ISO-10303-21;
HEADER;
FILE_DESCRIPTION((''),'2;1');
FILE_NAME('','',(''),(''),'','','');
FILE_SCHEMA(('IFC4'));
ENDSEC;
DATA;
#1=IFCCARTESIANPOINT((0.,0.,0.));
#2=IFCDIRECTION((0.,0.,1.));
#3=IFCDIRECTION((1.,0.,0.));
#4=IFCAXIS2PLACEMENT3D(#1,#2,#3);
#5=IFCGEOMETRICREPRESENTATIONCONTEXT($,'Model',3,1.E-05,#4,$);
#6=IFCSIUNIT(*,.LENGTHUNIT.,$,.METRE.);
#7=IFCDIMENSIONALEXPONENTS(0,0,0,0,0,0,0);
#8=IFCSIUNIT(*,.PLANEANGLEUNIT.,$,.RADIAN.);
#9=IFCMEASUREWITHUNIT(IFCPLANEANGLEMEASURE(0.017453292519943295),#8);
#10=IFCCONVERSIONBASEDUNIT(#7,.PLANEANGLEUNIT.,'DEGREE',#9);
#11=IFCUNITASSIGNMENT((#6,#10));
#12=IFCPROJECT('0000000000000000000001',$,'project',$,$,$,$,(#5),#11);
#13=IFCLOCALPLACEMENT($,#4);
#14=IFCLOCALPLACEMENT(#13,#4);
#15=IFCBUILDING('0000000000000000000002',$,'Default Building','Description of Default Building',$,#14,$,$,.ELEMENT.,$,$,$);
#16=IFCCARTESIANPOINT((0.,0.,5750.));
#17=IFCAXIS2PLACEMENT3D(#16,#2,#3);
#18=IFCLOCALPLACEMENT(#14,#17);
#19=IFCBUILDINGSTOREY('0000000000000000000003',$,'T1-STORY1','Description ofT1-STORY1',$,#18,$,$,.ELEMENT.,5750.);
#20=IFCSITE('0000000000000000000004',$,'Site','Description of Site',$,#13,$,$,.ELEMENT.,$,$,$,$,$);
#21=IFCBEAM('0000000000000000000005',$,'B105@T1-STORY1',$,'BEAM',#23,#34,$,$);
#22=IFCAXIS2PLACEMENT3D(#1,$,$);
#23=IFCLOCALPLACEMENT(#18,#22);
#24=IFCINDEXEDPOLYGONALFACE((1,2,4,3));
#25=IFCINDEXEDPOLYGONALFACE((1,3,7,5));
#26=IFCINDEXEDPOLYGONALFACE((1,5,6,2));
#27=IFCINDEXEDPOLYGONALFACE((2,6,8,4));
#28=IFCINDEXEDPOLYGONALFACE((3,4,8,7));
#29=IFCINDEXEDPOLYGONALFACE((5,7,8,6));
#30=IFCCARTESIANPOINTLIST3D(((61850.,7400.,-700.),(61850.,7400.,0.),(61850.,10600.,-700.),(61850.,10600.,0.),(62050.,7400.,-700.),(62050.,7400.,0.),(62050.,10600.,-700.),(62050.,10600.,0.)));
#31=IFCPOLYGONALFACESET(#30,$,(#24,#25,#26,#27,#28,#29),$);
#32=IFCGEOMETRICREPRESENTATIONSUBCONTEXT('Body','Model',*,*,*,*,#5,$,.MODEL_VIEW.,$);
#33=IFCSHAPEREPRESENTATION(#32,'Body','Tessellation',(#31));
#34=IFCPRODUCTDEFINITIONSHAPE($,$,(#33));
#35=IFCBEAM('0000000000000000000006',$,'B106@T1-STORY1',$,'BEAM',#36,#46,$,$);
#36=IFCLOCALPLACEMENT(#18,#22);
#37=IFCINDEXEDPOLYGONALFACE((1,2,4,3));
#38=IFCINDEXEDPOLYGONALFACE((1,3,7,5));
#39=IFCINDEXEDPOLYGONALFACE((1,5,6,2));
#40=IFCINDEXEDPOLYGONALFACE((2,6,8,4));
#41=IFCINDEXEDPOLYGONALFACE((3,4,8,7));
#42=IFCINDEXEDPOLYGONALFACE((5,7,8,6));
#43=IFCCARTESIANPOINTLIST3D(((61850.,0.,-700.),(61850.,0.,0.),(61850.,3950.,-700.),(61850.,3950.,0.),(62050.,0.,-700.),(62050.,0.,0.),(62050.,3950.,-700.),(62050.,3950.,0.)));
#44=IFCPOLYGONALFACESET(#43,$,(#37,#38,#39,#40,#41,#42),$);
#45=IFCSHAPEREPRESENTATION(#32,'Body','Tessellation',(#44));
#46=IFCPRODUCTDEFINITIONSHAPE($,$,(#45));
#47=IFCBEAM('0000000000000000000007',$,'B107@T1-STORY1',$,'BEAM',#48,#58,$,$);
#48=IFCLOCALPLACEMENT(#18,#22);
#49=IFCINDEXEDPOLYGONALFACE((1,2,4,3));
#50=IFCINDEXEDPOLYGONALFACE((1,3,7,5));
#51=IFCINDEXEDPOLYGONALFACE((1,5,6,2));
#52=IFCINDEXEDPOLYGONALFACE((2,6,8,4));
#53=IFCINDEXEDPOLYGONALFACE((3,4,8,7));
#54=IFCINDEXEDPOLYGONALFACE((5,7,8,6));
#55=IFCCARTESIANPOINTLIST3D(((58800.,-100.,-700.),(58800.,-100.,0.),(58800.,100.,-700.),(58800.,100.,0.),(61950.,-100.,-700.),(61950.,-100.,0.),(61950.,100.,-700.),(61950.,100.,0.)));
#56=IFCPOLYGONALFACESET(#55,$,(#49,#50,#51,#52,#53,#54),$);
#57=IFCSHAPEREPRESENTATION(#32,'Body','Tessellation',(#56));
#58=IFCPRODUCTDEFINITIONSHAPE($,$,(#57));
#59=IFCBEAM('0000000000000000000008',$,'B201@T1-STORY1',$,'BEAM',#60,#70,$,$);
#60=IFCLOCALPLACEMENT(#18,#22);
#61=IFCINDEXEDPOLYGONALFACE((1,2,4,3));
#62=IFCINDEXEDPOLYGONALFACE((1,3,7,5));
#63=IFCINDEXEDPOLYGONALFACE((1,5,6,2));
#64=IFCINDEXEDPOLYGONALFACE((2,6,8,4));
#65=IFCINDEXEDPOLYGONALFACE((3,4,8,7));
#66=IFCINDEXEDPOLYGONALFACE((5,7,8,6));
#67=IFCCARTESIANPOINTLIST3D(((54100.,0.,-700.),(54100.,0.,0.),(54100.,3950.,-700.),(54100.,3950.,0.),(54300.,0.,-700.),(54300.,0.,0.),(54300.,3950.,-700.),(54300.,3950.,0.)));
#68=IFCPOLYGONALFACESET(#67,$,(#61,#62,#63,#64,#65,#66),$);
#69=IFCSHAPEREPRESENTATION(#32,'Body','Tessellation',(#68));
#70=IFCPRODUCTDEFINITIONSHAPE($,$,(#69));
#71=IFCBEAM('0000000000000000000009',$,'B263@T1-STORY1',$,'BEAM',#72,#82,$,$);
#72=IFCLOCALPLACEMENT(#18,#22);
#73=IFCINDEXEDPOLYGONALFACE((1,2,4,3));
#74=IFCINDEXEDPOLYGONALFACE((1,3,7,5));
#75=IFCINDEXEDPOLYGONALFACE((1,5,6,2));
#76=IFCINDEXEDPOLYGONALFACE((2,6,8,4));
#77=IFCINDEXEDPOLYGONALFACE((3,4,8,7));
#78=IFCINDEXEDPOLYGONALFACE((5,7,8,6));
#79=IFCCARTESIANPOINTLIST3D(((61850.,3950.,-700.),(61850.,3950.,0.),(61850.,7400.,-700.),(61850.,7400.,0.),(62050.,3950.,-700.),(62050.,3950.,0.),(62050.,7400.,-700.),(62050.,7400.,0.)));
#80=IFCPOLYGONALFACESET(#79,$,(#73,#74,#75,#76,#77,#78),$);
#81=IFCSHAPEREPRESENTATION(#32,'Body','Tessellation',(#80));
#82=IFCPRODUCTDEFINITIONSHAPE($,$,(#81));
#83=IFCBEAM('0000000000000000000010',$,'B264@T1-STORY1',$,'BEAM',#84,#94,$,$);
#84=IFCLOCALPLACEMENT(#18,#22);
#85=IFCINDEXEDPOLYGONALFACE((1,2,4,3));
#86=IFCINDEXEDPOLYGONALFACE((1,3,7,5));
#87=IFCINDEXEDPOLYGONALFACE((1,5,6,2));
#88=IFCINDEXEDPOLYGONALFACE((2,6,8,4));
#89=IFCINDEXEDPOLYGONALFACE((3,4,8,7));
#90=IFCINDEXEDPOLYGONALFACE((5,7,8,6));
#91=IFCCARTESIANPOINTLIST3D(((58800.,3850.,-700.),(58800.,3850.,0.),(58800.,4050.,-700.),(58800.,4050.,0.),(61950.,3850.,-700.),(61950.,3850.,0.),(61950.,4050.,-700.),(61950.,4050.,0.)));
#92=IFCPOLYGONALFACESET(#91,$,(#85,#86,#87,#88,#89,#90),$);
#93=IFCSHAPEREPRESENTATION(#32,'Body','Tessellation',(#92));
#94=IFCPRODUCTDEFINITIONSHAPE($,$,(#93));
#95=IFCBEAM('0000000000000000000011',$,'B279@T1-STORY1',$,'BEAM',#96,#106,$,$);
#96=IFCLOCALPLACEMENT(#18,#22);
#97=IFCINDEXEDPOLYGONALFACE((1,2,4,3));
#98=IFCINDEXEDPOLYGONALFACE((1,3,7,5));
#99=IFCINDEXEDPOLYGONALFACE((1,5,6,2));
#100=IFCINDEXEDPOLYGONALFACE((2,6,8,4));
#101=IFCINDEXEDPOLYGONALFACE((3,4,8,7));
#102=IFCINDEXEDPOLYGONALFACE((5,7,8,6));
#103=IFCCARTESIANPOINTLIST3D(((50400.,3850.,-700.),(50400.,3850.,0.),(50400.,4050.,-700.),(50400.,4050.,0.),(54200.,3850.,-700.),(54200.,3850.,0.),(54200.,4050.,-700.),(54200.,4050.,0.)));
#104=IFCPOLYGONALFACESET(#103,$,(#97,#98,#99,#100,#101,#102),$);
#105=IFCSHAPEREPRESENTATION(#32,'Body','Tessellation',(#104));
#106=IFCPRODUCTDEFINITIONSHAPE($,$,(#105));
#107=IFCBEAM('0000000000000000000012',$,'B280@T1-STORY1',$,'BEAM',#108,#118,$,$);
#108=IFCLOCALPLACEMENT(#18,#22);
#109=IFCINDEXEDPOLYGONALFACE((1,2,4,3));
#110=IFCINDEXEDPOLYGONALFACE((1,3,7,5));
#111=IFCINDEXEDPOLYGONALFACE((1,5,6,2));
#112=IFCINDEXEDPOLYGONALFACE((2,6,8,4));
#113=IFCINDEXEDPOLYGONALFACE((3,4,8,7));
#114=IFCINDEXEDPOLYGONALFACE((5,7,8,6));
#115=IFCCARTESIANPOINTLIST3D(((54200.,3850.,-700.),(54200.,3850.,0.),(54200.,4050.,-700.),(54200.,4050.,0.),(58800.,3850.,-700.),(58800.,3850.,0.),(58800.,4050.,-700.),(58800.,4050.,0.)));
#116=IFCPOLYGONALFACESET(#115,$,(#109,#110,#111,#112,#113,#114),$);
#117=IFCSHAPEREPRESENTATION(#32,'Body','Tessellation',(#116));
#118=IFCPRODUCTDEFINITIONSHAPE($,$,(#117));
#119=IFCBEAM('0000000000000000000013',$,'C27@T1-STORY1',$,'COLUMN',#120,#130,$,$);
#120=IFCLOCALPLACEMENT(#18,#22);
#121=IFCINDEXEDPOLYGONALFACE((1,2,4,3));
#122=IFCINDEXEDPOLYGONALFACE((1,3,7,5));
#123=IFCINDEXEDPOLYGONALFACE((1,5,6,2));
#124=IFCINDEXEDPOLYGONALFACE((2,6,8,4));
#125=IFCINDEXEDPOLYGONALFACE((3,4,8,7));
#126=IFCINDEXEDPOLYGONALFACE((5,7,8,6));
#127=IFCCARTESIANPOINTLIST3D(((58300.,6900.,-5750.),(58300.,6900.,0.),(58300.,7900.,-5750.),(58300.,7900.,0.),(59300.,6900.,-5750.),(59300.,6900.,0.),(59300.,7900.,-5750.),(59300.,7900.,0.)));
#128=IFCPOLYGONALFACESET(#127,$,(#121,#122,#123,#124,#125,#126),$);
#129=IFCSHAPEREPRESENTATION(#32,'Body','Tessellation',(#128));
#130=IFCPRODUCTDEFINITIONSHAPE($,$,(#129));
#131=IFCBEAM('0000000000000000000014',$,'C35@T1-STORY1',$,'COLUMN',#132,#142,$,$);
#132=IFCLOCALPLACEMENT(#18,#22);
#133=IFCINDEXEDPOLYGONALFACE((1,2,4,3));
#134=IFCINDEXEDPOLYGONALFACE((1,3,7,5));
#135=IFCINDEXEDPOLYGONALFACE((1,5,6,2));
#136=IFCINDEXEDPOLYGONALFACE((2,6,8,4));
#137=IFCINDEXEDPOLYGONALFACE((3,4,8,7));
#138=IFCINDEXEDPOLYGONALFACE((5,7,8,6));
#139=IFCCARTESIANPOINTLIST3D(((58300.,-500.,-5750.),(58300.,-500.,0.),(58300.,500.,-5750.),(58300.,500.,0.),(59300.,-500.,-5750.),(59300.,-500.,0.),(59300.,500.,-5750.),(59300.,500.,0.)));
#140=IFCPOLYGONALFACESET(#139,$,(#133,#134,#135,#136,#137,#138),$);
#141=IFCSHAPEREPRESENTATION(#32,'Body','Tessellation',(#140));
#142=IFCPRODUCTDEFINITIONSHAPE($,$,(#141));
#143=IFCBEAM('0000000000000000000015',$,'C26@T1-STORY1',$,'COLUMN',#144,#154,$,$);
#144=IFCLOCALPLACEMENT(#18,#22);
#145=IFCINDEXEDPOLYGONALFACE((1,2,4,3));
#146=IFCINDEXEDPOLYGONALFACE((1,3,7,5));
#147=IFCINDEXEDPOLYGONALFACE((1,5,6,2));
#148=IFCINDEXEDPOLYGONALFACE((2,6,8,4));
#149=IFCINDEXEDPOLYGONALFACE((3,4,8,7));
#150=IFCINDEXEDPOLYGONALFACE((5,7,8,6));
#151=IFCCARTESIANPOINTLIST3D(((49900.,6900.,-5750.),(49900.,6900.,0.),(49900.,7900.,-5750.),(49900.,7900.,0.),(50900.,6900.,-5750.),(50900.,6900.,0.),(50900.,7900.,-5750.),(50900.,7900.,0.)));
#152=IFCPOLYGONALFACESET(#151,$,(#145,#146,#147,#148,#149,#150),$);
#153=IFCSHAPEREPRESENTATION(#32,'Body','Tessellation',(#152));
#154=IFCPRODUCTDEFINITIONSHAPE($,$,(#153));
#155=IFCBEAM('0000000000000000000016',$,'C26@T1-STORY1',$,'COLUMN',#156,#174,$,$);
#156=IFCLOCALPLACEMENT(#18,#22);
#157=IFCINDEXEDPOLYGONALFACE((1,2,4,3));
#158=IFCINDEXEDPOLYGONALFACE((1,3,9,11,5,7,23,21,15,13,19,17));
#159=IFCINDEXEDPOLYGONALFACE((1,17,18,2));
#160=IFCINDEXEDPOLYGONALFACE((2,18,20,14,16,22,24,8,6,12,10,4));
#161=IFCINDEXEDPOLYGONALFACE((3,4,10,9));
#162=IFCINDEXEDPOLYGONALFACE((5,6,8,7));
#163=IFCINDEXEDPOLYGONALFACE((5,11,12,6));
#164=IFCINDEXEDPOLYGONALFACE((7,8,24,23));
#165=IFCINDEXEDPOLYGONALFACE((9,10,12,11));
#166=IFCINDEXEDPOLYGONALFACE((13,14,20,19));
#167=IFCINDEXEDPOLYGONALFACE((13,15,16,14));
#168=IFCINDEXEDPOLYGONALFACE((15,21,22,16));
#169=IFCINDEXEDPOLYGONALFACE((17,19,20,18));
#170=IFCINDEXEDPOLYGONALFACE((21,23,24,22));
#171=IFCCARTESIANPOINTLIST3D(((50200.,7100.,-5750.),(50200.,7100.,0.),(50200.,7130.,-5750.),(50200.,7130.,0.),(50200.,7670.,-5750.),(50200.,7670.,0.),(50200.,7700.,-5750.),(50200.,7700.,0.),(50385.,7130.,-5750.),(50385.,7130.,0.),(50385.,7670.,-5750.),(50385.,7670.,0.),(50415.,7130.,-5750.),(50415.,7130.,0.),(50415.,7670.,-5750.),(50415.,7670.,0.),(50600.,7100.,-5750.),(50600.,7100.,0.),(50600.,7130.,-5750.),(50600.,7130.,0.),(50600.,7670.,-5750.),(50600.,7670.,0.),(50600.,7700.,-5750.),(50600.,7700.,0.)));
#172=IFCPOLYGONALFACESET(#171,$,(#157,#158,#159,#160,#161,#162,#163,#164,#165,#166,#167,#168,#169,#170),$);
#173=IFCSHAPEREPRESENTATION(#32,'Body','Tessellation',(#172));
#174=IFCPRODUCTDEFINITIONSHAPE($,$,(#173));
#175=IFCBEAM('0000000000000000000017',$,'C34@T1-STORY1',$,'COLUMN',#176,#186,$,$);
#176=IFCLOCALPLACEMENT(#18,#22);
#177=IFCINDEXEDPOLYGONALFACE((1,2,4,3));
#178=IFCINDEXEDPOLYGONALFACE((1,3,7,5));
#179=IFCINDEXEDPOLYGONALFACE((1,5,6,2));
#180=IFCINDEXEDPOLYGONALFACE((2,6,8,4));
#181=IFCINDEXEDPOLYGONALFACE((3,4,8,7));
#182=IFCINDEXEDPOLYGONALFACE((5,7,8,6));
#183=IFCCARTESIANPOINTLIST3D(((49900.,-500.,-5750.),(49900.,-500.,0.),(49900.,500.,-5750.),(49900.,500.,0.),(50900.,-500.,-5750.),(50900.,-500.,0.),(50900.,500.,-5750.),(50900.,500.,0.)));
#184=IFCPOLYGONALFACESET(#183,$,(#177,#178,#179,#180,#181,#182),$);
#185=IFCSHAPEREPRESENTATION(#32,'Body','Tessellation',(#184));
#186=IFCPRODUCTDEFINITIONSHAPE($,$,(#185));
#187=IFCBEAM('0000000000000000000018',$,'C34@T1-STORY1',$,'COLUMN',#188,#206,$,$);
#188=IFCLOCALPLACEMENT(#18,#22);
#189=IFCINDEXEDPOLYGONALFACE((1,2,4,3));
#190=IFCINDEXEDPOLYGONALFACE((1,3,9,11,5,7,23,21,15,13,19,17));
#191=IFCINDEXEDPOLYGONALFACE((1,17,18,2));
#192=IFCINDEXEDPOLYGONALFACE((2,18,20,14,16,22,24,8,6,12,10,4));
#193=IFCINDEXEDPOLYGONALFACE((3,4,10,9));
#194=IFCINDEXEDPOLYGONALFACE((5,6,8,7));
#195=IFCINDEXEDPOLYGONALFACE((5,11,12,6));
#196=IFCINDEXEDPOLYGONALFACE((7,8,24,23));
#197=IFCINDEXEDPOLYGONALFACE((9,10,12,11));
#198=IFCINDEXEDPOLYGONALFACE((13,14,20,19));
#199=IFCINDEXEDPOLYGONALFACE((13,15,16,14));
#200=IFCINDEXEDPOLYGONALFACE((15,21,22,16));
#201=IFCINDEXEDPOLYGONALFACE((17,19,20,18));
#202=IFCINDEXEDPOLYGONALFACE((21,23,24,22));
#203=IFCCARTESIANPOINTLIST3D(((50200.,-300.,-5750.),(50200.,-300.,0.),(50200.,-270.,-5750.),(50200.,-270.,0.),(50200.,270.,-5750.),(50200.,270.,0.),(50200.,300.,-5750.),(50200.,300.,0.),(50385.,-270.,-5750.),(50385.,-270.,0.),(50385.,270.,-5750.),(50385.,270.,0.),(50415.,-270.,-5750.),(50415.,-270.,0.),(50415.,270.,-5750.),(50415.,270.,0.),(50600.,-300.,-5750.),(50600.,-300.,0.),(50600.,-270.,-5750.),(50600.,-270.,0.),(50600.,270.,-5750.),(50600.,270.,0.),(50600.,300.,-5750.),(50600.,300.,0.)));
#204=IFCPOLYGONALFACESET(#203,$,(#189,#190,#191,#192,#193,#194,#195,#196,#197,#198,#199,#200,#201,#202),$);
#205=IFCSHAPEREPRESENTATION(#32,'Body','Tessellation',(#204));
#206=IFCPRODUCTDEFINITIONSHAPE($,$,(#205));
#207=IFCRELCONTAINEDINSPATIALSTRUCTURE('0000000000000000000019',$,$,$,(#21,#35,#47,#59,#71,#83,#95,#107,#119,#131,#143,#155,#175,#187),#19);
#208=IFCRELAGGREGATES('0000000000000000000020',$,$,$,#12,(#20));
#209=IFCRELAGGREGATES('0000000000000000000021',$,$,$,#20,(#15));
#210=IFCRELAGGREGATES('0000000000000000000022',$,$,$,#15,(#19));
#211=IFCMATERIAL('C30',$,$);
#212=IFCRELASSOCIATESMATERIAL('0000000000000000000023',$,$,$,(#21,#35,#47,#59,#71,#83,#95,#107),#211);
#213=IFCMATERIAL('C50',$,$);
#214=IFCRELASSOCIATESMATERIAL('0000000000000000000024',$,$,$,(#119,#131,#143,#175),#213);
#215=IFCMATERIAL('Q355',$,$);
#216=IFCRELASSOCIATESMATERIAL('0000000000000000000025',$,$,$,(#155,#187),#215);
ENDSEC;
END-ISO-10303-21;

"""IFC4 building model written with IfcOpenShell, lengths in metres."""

from ifc_helpers import new_model, entity, si_unit, converted_unit, frame, origin_with_axes, place, context, subcontext, project, spatial, rectangle, i_section, extrude, material, element, save


model = new_model("IFC4")

# Units and contexts
model_context = context("Model", 3, precision=1e-05, world=origin_with_axes())
body_context = subcontext(model_context, "Body", "Model", "MODEL_VIEW")
ifc_project = project(units=[si_unit("LENGTHUNIT", "METRE"), converted_unit("PLANEANGLEUNIT", "DEGREE", entity("IfcPlaneAngleMeasure", 0.017453292519943295), si_unit("PLANEANGLEUNIT", "RADIAN"), dimensions=[0, 0, 0, 0, 0, 0, 0])], contexts=[model_context])

# Site, building, storey
site_placement = place(None, origin_with_axes())
site = spatial("IfcSite", under=ifc_project, at=site_placement, Name="Site", Description="Description of Site", CompositionType="ELEMENT")
building_placement = place(site_placement, origin_with_axes())
building = spatial("IfcBuilding", under=site, at=building_placement, Name="Default Building", Description="Description of Default Building", CompositionType="ELEMENT")
storey_placement = place(building_placement, frame((0.0, 0.0, 5750.0), z_axis=(0.0, 0.0, 1.0), x_axis=(1.0, 0.0, 0.0)))
storey = spatial("IfcBuildingStorey", under=building, at=storey_placement, Name="T1-STORY1", Description="Description ofT1-STORY1", CompositionType="ELEMENT", Elevation=5750.0)

# Beams
ifc_material_1 = material(Name="C30")
beam_1_placement = place(storey_placement, frame((61950.0, 7400.0, -350.0), z_axis=(0.0, 1.0, 0.0), x_axis=(-1.0, 0.0, 0.0)))
element("IfcBeam", 1, at=beam_1_placement, inside=storey, material=ifc_material_1, Name="B105@T1-STORY1", ObjectType="BEAM", context=body_context, shape_type="SweptSolid", body=[
    extrude(rectangle(XDim=200.0, YDim=700.0), origin_with_axes(), (0.0, 0.0, 1.0), 3200.0),
])
beam_2_placement = place(storey_placement, frame((61950.0, 0.0, -350.0), z_axis=(0.0, 1.0, 0.0), x_axis=(-1.0, 0.0, 0.0)))
element("IfcBeam", 2, at=beam_2_placement, inside=storey, material=ifc_material_1, Name="B106@T1-STORY1", ObjectType="BEAM", context=body_context, shape_type="SweptSolid", body=[
    extrude(rectangle(XDim=200.0, YDim=700.0), origin_with_axes(), (0.0, 0.0, 1.0), 3950.0),
])
beam_3_placement = place(storey_placement, frame((58800.0, 0.0, -350.0), z_axis=(1.0, 0.0, 0.0), x_axis=(0.0, 1.0, 0.0)))
element("IfcBeam", 3, at=beam_3_placement, inside=storey, material=ifc_material_1, Name="B107@T1-STORY1", ObjectType="BEAM", context=body_context, shape_type="SweptSolid", body=[
    extrude(rectangle(XDim=200.0, YDim=700.0), origin_with_axes(), (0.0, 0.0, 1.0), 3150.0),
])
beam_4_placement = place(storey_placement, frame((54200.0, 0.0, -350.0), z_axis=(0.0, 1.0, 0.0), x_axis=(-1.0, 0.0, 0.0)))
element("IfcBeam", 4, at=beam_4_placement, inside=storey, material=ifc_material_1, Name="B201@T1-STORY1", ObjectType="BEAM", context=body_context, shape_type="SweptSolid", body=[
    extrude(rectangle(XDim=200.0, YDim=700.0), origin_with_axes(), (0.0, 0.0, 1.0), 3950.0),
])
beam_5_placement = place(storey_placement, frame((61950.0, 3950.0, -350.0), z_axis=(0.0, 1.0, 0.0), x_axis=(-1.0, 0.0, 0.0)))
element("IfcBeam", 5, at=beam_5_placement, inside=storey, material=ifc_material_1, Name="B263@T1-STORY1", ObjectType="BEAM", context=body_context, shape_type="SweptSolid", body=[
    extrude(rectangle(XDim=200.0, YDim=700.0), origin_with_axes(), (0.0, 0.0, 1.0), 3450.0),
])
beam_6_placement = place(storey_placement, frame((58800.0, 3950.0, -350.0), z_axis=(1.0, 0.0, 0.0), x_axis=(0.0, 1.0, 0.0)))
element("IfcBeam", 6, at=beam_6_placement, inside=storey, material=ifc_material_1, Name="B264@T1-STORY1", ObjectType="BEAM", context=body_context, shape_type="SweptSolid", body=[
    extrude(rectangle(XDim=200.0, YDim=700.0), origin_with_axes(), (0.0, 0.0, 1.0), 3150.0),
])
beam_7_placement = place(storey_placement, frame((50400.0, 3950.0, -350.0), z_axis=(1.0, 0.0, 0.0), x_axis=(0.0, 1.0, 0.0)))
element("IfcBeam", 7, at=beam_7_placement, inside=storey, material=ifc_material_1, Name="B279@T1-STORY1", ObjectType="BEAM", context=body_context, shape_type="SweptSolid", body=[
    extrude(rectangle(XDim=200.0, YDim=700.0), origin_with_axes(), (0.0, 0.0, 1.0), 3800.0),
])
beam_8_placement = place(storey_placement, frame((54200.0, 3950.0, -350.0), z_axis=(1.0, 0.0, 0.0), x_axis=(0.0, 1.0, 0.0)))
element("IfcBeam", 8, at=beam_8_placement, inside=storey, material=ifc_material_1, Name="B280@T1-STORY1", ObjectType="BEAM", context=body_context, shape_type="SweptSolid", body=[
    extrude(rectangle(XDim=200.0, YDim=700.0), origin_with_axes(), (0.0, 0.0, 1.0), 4600.0),
])
ifc_material_2 = material(Name="C50")
for number, where, z_axis, x_axis, name in (
    (9, (58800.0, 7400.0, -5750.0), (0.0, 0.0, 1.0), (-1.0, 0.0, 0.0), "C27@T1-STORY1"),
    (10, (58800.0, 0.0, -5750.0), (0.0, 0.0, 1.0), (-1.0, 0.0, 0.0), "C35@T1-STORY1"),
    (11, (50400.0, 7400.0, -5750.0), (0.0, 0.0, 1.0), (-1.0, 0.0, 0.0), "C26@T1-STORY1"),
):
    element("IfcBeam", number, at=place(storey_placement, frame(where, z_axis=z_axis, x_axis=x_axis)), inside=storey, material=ifc_material_2, Name=name, ObjectType="COLUMN", context=body_context, shape_type="SweptSolid", body=[
        extrude(rectangle(XDim=1000.0, YDim=1000.0), origin_with_axes(), (0.0, 0.0, 1.0), 5750.0),
    ])
ifc_material_3 = material(Name="Q355")
beam_9_placement = place(storey_placement, frame((50400.0, 7400.0, -5750.0), z_axis=(0.0, 0.0, 1.0), x_axis=(-1.0, 0.0, 0.0)))
element("IfcBeam", 12, at=beam_9_placement, inside=storey, material=ifc_material_3, Name="C26@T1-STORY1", ObjectType="COLUMN", context=body_context, shape_type="SweptSolid", body=[
    extrude(i_section(OverallWidth=400.0, OverallDepth=600.0, WebThickness=30.0, FlangeThickness=30.0, FilletRadius=0.0), origin_with_axes(), (0.0, 0.0, 1.0), 5750.0),
])
beam_10_placement = place(storey_placement, frame((50400.0, 0.0, -5750.0), z_axis=(0.0, 0.0, 1.0), x_axis=(-1.0, 0.0, 0.0)))
element("IfcBeam", 13, at=beam_10_placement, inside=storey, material=ifc_material_2, Name="C34@T1-STORY1", ObjectType="COLUMN", context=body_context, shape_type="SweptSolid", body=[
    extrude(rectangle(XDim=1000.0, YDim=1000.0), origin_with_axes(), (0.0, 0.0, 1.0), 5750.0),
])
beam_11_placement = place(storey_placement, frame((50400.0, 0.0, -5750.0), z_axis=(0.0, 0.0, 1.0), x_axis=(-1.0, 0.0, 0.0)))
element("IfcBeam", 14, at=beam_11_placement, inside=storey, material=ifc_material_3, Name="C34@T1-STORY1", ObjectType="COLUMN", context=body_context, shape_type="SweptSolid", body=[
    extrude(i_section(OverallWidth=400.0, OverallDepth=600.0, WebThickness=30.0, FlangeThickness=30.0, FilletRadius=0.0), origin_with_axes(), (0.0, 0.0, 1.0), 5750.0),
])

save(model, "model.ifc")
